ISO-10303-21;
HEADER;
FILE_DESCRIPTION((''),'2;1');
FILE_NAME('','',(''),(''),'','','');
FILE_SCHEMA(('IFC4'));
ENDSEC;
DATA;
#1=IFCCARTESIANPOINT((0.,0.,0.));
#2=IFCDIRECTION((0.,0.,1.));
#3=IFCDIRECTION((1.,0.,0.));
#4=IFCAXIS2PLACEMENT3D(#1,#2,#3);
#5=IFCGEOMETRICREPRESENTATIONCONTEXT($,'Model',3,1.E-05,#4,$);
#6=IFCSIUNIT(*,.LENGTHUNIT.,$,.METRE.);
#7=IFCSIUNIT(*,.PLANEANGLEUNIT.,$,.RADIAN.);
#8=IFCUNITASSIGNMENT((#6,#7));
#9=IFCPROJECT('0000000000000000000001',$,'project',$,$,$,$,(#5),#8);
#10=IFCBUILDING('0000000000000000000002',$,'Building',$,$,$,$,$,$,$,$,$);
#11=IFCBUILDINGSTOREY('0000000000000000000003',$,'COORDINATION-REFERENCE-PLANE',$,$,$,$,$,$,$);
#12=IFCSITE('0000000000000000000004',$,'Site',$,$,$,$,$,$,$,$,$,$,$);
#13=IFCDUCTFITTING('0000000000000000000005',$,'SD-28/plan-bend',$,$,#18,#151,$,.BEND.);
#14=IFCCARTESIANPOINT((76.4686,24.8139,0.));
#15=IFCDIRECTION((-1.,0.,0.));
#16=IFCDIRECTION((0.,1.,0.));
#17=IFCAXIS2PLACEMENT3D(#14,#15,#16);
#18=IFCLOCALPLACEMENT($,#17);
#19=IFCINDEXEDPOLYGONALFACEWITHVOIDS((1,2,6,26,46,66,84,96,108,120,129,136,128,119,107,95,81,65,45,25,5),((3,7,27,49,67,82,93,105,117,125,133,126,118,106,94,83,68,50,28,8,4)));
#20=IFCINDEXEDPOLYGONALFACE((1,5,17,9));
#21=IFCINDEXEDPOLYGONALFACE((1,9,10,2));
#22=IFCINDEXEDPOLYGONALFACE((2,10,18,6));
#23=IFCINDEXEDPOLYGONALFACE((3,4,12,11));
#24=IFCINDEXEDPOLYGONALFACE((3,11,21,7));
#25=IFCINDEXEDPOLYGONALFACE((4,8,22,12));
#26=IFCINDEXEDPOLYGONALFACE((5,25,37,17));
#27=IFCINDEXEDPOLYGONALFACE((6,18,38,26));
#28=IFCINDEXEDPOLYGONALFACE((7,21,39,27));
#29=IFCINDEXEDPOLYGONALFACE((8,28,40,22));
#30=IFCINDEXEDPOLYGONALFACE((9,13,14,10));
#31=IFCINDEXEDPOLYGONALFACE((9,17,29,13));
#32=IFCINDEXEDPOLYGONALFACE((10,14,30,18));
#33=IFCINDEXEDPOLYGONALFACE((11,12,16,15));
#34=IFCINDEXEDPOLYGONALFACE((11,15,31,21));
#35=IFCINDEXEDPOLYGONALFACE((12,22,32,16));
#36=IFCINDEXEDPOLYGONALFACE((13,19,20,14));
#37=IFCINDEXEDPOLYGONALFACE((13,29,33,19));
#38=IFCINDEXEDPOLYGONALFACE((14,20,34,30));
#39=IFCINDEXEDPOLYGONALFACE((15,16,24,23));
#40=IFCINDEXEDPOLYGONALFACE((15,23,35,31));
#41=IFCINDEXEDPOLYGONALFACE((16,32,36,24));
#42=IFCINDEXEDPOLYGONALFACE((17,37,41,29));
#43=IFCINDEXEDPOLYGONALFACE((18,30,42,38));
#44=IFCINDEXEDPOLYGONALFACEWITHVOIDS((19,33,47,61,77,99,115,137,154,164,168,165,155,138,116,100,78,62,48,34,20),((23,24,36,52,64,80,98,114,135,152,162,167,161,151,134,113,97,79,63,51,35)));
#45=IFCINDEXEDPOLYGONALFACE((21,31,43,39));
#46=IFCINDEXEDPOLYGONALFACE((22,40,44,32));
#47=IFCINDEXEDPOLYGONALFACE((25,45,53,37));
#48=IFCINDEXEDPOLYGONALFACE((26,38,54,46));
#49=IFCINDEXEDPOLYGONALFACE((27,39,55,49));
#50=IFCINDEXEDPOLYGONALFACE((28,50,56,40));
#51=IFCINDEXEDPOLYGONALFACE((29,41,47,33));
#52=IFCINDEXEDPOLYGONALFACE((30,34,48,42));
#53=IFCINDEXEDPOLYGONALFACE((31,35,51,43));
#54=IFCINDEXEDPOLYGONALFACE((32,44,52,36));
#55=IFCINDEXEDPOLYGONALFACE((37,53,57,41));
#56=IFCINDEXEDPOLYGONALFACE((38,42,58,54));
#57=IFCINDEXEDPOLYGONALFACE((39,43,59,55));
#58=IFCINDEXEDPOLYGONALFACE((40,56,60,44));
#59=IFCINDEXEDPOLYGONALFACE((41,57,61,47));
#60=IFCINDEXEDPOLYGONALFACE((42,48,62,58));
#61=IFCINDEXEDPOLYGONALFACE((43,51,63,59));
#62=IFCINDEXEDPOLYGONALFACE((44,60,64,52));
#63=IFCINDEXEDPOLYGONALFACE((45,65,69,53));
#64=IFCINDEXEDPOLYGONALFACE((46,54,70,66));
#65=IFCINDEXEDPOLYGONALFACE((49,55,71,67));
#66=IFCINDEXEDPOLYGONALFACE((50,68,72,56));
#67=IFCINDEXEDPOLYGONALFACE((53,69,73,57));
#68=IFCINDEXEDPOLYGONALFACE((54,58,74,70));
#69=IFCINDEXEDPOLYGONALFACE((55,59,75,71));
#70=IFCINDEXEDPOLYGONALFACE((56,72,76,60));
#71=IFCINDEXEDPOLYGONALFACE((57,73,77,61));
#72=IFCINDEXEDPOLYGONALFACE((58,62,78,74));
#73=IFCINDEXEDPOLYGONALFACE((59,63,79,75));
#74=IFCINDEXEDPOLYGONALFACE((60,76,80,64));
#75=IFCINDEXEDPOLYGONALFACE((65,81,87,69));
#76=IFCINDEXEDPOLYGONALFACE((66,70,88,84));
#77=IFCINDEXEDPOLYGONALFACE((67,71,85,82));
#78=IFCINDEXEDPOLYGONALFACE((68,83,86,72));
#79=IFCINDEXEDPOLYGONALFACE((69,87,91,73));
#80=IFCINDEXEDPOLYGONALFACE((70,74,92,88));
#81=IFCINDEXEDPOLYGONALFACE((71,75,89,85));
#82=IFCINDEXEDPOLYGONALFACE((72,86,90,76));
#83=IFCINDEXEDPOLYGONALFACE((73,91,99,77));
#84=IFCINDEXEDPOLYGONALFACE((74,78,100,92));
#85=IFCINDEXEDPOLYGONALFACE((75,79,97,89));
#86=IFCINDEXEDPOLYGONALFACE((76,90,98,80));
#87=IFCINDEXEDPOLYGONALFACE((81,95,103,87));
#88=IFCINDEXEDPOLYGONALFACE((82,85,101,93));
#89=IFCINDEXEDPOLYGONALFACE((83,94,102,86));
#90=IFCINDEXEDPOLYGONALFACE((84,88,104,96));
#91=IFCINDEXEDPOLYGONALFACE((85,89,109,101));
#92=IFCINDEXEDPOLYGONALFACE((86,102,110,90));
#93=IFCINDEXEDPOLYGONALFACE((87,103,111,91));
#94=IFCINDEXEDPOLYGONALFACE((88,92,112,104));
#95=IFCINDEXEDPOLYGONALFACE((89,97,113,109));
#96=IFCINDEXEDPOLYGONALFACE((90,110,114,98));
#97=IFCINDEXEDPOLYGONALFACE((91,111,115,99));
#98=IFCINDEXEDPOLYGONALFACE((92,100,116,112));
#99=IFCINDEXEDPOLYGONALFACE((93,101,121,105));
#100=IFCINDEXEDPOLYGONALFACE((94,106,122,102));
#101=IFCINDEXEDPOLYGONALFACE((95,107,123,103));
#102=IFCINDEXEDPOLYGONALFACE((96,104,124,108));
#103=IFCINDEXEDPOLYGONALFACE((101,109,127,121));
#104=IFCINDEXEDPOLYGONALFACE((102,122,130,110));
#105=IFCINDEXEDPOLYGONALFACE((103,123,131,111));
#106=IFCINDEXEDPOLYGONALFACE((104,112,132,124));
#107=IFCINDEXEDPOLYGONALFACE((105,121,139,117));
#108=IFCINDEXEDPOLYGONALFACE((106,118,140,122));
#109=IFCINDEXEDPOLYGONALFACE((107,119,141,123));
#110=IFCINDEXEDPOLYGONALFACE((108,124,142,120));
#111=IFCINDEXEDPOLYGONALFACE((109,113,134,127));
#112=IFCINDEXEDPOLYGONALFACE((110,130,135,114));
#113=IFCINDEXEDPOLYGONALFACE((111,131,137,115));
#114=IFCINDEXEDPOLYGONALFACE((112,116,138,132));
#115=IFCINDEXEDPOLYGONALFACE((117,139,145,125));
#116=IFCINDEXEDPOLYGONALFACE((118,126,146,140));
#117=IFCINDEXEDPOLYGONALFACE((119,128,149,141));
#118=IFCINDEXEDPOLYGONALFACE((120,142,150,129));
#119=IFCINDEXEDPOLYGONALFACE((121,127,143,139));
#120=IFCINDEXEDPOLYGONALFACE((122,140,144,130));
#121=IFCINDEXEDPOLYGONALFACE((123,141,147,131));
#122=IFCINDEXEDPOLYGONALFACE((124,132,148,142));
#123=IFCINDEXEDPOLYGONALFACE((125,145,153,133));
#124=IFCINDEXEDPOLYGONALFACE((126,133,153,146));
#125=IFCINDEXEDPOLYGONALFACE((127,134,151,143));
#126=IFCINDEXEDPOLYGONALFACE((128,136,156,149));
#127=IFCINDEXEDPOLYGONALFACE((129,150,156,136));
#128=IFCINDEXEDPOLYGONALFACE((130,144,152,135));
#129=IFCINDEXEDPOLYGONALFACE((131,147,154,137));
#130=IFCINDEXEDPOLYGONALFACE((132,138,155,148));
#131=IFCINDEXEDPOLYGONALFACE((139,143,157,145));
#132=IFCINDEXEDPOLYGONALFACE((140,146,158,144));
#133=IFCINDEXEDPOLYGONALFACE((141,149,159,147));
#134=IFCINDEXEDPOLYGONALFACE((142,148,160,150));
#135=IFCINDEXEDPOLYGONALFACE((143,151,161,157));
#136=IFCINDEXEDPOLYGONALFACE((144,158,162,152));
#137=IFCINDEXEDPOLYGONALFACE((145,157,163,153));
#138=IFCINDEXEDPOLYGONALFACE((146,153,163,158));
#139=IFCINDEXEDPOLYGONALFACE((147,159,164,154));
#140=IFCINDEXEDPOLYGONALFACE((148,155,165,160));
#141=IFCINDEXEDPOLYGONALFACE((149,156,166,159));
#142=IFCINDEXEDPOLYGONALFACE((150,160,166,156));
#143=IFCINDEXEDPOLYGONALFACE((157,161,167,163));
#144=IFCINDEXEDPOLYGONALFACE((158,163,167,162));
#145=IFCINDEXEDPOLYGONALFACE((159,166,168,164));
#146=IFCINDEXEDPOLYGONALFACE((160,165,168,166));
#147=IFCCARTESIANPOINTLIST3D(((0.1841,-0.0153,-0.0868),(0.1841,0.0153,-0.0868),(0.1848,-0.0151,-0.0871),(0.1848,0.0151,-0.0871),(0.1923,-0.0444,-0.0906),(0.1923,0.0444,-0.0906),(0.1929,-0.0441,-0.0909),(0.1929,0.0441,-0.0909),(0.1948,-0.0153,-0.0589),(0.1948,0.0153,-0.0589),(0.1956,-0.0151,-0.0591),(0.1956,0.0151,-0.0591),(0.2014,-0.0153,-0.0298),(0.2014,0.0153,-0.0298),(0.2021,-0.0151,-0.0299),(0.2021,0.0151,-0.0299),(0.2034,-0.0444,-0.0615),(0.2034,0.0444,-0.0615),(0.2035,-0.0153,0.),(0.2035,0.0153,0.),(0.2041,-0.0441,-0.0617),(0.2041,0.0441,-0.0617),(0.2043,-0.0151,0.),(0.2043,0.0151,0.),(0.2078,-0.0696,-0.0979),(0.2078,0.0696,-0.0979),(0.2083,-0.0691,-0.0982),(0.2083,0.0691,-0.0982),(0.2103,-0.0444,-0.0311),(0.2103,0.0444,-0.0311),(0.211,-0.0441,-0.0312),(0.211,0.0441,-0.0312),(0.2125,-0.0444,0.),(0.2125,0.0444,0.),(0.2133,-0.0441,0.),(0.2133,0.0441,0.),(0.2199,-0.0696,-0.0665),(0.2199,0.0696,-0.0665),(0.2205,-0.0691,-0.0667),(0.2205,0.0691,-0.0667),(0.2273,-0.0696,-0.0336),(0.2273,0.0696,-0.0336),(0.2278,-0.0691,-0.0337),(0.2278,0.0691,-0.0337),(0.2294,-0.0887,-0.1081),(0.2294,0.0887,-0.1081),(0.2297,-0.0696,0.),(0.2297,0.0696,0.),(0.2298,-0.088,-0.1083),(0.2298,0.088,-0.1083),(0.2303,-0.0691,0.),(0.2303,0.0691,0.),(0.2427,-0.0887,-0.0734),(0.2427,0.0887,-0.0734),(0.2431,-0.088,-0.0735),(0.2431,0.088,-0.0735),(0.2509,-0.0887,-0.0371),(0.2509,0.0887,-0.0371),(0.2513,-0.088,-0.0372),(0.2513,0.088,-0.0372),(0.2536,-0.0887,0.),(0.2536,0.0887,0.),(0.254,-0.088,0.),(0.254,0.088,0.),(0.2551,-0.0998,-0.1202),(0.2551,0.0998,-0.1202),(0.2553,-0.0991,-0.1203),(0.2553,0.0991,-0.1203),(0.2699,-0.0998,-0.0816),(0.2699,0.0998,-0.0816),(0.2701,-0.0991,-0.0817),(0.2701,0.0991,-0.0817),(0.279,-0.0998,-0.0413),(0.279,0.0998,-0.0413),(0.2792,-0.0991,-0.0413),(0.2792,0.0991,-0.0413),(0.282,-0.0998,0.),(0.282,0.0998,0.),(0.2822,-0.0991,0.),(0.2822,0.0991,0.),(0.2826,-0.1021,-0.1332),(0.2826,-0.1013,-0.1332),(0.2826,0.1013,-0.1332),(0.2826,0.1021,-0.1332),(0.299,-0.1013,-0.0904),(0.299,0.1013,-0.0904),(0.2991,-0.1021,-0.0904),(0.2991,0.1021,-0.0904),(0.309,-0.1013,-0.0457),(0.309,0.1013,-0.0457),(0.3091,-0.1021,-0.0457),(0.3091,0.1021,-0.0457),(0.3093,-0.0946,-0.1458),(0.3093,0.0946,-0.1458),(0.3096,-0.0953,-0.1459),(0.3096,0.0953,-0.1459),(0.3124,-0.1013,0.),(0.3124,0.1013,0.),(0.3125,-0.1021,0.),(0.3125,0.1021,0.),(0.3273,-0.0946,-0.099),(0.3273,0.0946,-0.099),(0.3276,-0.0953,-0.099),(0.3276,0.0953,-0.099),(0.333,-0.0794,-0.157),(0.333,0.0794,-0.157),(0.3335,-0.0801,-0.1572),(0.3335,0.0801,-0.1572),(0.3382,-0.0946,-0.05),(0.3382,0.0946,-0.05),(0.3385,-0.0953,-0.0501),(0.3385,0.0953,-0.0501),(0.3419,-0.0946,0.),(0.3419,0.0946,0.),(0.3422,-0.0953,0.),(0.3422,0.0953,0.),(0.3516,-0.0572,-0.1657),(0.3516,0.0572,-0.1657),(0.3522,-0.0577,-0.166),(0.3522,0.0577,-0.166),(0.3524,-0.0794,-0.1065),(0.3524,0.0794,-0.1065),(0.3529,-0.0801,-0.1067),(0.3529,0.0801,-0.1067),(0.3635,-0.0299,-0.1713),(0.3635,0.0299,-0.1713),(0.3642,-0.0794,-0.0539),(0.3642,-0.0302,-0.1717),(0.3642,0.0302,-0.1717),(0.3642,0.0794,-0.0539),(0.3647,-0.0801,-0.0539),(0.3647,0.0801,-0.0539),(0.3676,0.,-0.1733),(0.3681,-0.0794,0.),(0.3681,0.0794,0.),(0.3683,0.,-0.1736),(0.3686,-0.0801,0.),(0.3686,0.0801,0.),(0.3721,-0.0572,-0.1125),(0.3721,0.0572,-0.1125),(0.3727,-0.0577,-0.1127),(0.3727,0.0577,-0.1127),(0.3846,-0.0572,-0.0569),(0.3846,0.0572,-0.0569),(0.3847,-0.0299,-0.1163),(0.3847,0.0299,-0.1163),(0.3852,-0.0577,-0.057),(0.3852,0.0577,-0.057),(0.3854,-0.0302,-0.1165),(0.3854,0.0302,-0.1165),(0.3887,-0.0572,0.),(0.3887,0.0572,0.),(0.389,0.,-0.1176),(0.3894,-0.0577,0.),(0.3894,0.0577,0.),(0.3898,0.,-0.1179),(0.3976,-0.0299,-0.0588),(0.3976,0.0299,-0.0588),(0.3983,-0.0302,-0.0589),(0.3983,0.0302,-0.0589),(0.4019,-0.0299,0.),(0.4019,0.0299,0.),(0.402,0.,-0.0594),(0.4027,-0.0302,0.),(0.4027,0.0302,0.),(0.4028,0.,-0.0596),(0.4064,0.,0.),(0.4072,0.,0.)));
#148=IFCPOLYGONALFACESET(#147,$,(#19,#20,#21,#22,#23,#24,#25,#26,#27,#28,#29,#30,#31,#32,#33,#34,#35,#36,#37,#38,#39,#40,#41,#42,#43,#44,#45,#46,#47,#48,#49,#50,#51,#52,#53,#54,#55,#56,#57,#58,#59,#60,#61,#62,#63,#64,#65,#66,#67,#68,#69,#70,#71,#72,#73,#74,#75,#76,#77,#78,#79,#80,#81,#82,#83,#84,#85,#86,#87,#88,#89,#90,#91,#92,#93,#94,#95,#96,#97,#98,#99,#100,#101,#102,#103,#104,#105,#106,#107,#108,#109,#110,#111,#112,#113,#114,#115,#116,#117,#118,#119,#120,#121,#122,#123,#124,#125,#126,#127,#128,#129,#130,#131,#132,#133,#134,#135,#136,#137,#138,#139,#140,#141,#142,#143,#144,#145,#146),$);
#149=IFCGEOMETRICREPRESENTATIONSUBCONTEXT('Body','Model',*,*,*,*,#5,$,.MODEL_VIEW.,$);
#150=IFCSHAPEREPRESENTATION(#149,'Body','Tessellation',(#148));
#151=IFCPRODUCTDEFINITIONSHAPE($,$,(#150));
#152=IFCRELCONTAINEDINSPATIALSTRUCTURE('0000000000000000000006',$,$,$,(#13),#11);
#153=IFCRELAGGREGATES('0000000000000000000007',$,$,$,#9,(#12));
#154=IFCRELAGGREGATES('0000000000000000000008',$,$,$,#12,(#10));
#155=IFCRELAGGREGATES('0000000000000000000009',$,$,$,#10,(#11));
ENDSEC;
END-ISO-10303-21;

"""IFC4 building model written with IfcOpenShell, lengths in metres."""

from ifc_helpers import new_model, entity, si_unit, frame, origin_with_axes, place, context, subcontext, project, spatial, element, save


model = new_model("IFC4")

# Units and contexts
model_context_1 = context("Model", 3, precision=1e-05, world=origin_with_axes())
body_context_1 = subcontext(model_context_1, "Body", "Model", "MODEL_VIEW")
ifc_project = project(units=[si_unit("LENGTHUNIT", "METRE"), si_unit("PLANEANGLEUNIT", "RADIAN")], contexts=[model_context_1])

# Site, building, storey
site = spatial("IfcSite", under=ifc_project, Name="Site")
building = spatial("IfcBuilding", under=site, Name="Building")
storey = spatial("IfcBuildingStorey", under=building, Name="COORDINATION-REFERENCE-PLANE")

# Duct fitting
duct_fitting_1_placement = place(None, frame((76.4686, 24.8139, 0.0), z_axis=(-1.0, 0.0, 0.0), x_axis=(0.0, 1.0, 0.0)))
element("IfcDuctFitting", 1, at=duct_fitting_1_placement, inside=storey, Name="SD-28/plan-bend", PredefinedType="BEND", context=body_context_1, shape_type="SweptSolid", body=[
    entity("IfcRevolvedAreaSolid", entity("IfcCircleHollowProfileDef", "AREA", None, entity("IfcAxis2Placement2D", entity("IfcCartesianPoint", [0.3048, 0.0])), 0.1024, 0.0008), entity("IfcAxis2Placement3D", entity("IfcCartesianPoint", [0.0, 0.0, 0.0]), entity("IfcDirection", [0.0, 0.0, 1.0]), entity("IfcDirection", [1.0, 0.0, 0.0])), entity("IfcAxis1Placement", entity("IfcCartesianPoint", [0.0, 0.0, 0.0]), entity("IfcDirection", [0.0, 1.0, 0.0])), 0.440428),
])

save(model, "model.ifc")
